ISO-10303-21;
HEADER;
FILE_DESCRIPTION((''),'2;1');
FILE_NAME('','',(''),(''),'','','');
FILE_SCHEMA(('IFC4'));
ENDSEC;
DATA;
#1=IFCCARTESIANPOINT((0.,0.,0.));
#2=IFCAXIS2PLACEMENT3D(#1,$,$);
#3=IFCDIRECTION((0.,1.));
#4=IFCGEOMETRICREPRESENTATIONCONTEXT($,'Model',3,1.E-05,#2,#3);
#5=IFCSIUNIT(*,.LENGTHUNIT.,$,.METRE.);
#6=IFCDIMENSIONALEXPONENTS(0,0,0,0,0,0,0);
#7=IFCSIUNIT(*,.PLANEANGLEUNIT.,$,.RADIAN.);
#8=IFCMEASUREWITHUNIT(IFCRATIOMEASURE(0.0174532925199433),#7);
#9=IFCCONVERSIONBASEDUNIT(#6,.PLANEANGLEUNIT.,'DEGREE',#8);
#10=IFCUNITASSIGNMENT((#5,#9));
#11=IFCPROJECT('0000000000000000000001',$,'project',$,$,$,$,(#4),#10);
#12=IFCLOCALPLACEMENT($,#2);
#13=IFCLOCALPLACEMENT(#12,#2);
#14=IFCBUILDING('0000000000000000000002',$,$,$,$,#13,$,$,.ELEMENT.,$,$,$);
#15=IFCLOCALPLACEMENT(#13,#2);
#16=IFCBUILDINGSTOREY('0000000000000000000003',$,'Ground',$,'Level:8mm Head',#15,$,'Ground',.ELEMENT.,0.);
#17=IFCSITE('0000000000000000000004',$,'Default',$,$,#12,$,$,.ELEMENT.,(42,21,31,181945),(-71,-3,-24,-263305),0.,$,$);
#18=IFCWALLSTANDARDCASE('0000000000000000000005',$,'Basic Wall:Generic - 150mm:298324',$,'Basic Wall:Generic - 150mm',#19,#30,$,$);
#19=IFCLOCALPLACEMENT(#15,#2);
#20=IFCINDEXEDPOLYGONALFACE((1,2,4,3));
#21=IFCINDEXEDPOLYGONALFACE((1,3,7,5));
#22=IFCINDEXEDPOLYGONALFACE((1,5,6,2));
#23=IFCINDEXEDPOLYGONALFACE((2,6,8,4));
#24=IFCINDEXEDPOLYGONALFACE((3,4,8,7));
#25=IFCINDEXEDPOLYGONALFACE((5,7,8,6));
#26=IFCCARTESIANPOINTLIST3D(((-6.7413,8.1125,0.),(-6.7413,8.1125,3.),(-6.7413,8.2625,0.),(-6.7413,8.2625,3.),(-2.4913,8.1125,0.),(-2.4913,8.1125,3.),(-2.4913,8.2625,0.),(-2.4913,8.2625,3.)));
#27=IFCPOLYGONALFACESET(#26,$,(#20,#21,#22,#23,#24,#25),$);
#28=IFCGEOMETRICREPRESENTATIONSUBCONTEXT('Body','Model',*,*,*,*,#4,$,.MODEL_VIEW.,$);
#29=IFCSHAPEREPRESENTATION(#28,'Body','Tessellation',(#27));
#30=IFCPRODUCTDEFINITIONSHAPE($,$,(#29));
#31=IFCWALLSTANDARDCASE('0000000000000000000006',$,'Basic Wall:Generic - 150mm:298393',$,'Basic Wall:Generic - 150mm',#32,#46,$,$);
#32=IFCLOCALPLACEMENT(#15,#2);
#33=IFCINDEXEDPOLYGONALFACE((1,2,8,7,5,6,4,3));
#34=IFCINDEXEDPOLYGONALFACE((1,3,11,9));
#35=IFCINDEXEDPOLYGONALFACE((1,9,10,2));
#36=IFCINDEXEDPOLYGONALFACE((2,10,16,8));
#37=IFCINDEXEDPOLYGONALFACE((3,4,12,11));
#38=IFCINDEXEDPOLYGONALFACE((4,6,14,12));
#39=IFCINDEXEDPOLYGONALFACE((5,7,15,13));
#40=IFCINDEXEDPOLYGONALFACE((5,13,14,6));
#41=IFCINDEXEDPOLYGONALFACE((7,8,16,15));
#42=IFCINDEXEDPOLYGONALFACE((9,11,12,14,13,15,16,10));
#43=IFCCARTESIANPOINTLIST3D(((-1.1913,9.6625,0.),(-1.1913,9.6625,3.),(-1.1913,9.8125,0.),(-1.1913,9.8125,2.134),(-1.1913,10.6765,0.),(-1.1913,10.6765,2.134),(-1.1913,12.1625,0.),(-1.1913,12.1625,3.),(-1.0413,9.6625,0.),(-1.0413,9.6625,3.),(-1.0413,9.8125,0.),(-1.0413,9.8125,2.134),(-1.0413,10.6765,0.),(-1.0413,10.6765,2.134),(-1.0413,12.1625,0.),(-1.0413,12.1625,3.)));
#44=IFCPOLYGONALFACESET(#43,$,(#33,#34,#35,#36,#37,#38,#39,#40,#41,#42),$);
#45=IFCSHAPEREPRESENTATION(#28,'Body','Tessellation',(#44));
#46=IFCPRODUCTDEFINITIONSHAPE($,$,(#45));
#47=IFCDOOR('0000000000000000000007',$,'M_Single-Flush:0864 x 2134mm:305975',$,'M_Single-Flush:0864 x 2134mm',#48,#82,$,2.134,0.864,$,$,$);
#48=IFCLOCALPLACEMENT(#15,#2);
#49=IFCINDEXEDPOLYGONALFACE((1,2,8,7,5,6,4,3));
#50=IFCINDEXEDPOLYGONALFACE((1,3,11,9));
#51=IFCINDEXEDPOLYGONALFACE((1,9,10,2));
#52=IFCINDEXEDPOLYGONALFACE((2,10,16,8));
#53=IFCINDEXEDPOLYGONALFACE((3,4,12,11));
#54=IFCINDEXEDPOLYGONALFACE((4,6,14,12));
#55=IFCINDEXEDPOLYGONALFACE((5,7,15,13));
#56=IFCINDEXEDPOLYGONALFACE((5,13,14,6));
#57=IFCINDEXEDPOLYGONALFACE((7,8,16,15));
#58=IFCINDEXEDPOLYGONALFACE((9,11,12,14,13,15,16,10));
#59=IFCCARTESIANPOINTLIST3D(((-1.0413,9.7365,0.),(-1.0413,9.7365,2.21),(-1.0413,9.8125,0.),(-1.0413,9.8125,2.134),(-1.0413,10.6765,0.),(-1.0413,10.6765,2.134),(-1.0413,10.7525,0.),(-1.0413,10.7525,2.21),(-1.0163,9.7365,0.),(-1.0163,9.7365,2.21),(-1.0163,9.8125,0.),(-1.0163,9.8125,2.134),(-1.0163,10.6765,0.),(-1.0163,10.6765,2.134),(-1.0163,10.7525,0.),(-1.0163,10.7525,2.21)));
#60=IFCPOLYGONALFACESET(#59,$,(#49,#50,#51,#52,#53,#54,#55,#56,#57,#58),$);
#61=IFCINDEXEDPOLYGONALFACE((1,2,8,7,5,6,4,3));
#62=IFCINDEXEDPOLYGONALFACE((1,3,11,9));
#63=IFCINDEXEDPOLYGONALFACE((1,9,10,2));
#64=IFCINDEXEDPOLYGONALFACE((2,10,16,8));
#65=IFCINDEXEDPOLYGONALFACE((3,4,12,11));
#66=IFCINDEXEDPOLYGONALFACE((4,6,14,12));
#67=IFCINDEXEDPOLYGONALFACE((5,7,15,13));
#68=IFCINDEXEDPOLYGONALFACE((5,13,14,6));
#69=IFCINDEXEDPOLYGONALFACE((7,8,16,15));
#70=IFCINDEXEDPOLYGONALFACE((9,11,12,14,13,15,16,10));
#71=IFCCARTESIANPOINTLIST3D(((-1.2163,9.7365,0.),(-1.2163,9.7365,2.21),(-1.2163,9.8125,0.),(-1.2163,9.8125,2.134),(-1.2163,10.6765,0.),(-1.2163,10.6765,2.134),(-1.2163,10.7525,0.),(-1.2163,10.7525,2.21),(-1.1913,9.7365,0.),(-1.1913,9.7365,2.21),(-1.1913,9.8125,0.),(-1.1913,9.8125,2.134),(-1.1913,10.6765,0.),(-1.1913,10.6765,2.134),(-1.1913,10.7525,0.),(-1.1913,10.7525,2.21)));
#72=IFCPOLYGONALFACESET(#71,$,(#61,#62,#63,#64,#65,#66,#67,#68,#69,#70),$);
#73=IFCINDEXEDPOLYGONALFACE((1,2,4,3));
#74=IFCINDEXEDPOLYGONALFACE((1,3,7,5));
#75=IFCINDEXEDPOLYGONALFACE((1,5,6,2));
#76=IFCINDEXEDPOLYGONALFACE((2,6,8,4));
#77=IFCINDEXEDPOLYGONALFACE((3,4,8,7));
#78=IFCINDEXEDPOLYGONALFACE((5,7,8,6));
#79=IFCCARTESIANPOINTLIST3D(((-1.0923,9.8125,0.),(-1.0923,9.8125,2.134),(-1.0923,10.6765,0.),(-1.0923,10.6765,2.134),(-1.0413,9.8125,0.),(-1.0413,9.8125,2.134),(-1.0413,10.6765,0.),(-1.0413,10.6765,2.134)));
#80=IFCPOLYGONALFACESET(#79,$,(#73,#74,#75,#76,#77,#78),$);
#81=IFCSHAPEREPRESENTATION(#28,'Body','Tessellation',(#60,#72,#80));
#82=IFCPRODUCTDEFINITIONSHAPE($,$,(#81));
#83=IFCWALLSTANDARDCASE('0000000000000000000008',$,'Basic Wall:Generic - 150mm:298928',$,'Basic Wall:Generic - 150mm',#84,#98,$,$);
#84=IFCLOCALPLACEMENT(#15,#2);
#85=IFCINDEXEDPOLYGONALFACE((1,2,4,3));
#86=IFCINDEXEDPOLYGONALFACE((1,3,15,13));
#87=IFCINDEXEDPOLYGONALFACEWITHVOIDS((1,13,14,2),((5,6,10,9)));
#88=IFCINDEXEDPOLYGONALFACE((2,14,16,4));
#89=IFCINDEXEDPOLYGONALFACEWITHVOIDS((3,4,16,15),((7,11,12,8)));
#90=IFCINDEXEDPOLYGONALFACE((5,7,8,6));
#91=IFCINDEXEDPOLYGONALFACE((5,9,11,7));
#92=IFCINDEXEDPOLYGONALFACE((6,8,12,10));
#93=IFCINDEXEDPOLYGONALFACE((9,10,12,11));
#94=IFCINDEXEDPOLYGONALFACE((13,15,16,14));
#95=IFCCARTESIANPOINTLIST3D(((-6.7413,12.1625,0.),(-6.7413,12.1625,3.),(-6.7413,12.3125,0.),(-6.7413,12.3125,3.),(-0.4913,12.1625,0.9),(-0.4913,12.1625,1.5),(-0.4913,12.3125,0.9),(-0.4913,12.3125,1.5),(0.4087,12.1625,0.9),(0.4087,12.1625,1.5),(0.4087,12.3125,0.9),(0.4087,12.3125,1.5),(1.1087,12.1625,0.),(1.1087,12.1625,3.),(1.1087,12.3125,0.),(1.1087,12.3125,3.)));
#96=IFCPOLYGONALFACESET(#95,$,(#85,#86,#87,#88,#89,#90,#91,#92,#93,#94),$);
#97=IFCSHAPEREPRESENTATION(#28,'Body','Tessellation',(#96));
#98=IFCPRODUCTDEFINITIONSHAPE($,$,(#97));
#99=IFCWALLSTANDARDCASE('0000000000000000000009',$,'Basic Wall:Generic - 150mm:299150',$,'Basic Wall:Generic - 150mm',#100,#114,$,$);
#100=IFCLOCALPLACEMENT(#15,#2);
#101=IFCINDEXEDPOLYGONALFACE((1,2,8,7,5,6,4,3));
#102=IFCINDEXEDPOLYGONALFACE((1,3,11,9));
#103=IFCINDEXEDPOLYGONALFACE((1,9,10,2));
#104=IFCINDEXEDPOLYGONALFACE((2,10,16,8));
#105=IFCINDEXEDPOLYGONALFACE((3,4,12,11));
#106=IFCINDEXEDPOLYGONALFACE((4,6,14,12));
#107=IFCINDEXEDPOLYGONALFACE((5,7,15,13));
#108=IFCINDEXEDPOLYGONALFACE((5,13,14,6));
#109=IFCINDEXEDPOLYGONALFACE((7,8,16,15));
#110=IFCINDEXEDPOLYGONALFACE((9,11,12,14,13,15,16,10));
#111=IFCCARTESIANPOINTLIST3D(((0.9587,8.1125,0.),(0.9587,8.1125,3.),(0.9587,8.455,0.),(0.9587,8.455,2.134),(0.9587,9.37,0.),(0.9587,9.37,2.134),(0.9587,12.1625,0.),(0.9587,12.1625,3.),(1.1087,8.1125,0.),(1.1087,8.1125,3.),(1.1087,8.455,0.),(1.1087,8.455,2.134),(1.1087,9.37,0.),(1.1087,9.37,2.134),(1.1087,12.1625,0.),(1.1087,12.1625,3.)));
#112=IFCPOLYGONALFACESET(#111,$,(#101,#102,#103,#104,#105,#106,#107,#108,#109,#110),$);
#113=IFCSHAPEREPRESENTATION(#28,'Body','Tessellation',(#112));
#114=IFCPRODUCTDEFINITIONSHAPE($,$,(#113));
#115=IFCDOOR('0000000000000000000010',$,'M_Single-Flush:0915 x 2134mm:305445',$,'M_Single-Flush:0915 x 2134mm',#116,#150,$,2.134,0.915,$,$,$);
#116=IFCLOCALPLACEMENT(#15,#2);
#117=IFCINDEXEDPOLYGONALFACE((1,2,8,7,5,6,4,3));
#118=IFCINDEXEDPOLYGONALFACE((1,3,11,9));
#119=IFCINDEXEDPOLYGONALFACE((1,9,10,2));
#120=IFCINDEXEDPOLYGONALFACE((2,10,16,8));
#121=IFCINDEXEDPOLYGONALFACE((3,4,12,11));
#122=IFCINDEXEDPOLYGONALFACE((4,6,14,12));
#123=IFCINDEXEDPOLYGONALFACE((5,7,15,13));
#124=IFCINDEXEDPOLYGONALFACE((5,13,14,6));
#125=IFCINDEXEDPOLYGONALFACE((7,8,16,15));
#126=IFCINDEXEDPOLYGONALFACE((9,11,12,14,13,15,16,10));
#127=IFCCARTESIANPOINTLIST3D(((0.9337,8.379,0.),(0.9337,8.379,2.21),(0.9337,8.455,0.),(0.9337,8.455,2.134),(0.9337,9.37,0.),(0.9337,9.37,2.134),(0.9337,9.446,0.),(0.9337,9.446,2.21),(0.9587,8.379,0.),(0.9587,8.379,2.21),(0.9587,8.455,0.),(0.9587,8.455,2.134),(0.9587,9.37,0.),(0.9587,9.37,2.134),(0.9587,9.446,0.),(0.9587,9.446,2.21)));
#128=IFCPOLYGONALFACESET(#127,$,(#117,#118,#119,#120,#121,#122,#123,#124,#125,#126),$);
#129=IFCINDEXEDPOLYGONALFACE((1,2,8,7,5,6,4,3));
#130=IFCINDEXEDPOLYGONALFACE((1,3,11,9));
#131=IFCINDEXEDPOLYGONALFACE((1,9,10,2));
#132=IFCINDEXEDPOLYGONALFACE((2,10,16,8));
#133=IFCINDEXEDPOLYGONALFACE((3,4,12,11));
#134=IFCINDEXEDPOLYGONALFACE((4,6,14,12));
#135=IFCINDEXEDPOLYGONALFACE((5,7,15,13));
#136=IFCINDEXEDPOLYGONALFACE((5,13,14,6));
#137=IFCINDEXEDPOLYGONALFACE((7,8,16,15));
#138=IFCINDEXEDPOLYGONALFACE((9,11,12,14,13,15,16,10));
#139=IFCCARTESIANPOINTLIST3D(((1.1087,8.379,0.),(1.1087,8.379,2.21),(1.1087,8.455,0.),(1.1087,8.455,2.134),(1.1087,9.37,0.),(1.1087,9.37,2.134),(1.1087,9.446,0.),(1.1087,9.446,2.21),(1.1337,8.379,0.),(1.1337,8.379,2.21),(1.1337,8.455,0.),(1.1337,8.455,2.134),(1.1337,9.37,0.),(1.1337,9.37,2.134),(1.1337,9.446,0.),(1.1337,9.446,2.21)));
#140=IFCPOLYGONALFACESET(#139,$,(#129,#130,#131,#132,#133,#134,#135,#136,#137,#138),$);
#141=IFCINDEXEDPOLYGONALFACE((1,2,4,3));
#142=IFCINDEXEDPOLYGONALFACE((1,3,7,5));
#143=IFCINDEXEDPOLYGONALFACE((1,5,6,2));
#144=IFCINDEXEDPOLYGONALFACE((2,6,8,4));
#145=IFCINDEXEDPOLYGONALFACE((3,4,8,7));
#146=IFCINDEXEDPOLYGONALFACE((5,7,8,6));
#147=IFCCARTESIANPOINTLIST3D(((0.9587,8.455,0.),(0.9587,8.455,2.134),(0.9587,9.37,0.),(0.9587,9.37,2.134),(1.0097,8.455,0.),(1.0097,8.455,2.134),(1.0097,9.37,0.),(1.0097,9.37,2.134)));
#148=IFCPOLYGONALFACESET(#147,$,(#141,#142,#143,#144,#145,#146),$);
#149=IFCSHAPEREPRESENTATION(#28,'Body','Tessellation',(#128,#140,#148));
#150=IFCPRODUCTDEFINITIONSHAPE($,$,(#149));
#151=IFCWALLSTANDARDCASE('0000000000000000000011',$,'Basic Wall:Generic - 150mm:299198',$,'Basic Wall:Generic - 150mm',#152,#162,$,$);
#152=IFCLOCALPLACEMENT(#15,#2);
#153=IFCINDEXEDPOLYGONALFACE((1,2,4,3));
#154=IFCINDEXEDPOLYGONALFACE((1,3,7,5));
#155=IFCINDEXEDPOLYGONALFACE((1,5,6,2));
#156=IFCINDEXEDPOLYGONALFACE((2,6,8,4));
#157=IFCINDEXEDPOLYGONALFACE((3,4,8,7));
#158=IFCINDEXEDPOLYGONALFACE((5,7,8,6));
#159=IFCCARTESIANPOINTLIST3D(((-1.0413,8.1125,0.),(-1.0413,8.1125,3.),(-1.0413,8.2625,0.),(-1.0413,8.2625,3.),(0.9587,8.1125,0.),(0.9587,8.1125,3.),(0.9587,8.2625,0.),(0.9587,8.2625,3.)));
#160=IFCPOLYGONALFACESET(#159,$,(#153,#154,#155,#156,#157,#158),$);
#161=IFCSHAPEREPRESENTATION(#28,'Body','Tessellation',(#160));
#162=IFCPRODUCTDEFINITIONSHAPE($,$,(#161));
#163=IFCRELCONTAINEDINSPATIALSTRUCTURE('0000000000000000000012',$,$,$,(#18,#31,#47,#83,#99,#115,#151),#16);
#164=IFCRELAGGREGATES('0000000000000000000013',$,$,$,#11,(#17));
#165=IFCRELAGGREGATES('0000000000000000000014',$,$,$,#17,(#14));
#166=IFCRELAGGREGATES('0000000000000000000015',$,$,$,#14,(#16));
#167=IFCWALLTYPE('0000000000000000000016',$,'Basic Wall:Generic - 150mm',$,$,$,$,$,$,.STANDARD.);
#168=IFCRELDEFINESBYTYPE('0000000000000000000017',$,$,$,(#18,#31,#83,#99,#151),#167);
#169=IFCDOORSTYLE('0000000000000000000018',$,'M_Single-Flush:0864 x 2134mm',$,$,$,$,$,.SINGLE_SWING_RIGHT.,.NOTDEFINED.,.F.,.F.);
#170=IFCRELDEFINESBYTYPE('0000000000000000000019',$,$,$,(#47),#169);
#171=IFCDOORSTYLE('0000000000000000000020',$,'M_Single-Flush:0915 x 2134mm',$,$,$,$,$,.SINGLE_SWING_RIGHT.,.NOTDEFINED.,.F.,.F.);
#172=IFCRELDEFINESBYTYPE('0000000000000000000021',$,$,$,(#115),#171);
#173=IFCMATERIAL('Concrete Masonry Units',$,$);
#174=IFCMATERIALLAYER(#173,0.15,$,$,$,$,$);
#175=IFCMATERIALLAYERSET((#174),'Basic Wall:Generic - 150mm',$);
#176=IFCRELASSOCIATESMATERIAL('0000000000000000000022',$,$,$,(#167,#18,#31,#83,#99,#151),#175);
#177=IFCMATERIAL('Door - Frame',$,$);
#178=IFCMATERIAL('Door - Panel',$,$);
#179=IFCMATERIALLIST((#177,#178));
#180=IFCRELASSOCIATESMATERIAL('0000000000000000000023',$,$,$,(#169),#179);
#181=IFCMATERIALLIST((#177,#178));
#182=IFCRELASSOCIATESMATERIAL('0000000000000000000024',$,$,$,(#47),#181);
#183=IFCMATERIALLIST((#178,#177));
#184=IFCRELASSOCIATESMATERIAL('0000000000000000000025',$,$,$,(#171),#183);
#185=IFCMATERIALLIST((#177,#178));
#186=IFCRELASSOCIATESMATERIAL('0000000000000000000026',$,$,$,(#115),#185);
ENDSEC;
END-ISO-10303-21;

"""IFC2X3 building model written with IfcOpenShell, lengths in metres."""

from ifc_helpers import new_model, entity, si_unit, converted_unit, direction, frame, frame_2d, origin, place, context, subcontext, project, spatial, polyline, rectangle, outline, extrude, source, transform, mapped, material, material_list, layer, layer_set, layer_usage, type_object, type_shapes, element, fill, save


model = new_model("IFC2X3")

# Units and contexts
model_context = context("Model", 3, precision=1e-05, world=origin(), true_north=direction((0.0, 1.0)))
body_context = subcontext(model_context, "Body", "Model", "MODEL_VIEW")
ifc_project = project(units=[si_unit("LENGTHUNIT", "METRE"), converted_unit("PLANEANGLEUNIT", "DEGREE", entity("IfcRatioMeasure", 0.0174532925199433), si_unit("PLANEANGLEUNIT", "RADIAN"), dimensions=[0, 0, 0, 0, 0, 0, 0])], contexts=[model_context])

# Site, building, storey
site_placement = place(None, origin())
site = spatial("IfcSite", under=ifc_project, at=site_placement, Name="Default", CompositionType="ELEMENT", RefLatitude=(42, 21, 31, 181945), RefLongitude=(-71, -3, -24, -263305), RefElevation=0.0)
building_placement = place(site_placement, origin())
building = spatial("IfcBuilding", under=site, at=building_placement, CompositionType="ELEMENT")
storey_placement = place(building_placement, origin())
storey = spatial("IfcBuildingStorey", under=building, at=storey_placement, Name="Ground", ObjectType="Level:8mm Head", LongName="Ground", CompositionType="ELEMENT", Elevation=0.0)

# Wall
ifc_material_1 = material(Name="Concrete Masonry Units")
ifc_layer = layer(ifc_material_1, 0.15)
ifc_layer_set = layer_set([ifc_layer], Name="Basic Wall:Generic - 150mm")
ifc_layer_usage_1 = layer_usage(ifc_layer_set, "AXIS2", "POSITIVE", -0.075)
wall_type = type_object("IfcWallType", Name="Basic Wall:Generic - 150mm", PredefinedType="STANDARD", material=ifc_layer_set)
wall_1_placement = place(storey_placement, frame((-6.7413, 8.1875, 0.0)))
element("IfcWallStandardCase", 1, at=wall_1_placement, inside=storey, type_object=wall_type, material=ifc_layer_usage_1, Name="Basic Wall:Generic - 150mm:298324", ObjectType="Basic Wall:Generic - 150mm", context=body_context, shape_type="SweptSolid", body=[
    extrude(rectangle(XDim=4.25, YDim=0.15, at=frame_2d((2.125, 0.0), x_axis=(-1.0, 0.0))), origin(), (0.0, 0.0, 1.0), 3.0),
])

# Wall, opening, door
ifc_layer_usage_2 = layer_usage(ifc_layer_set, "AXIS2", "NEGATIVE", 0.075)
wall_2_placement = place(storey_placement, frame((-1.1163, 12.1625, 0.0), z_axis=(0.0, 0.0, 1.0), x_axis=(0.0, -1.0, 0.0)))
wall_2 = element("IfcWallStandardCase", 2, at=wall_2_placement, inside=storey, type_object=wall_type, material=ifc_layer_usage_2, Name="Basic Wall:Generic - 150mm:298393", ObjectType="Basic Wall:Generic - 150mm", context=body_context, shape_type="SweptSolid", body=[
    extrude(rectangle(XDim=2.5, YDim=0.15, at=frame_2d((1.25, 0.0), x_axis=(-1.0, 0.0))), origin(), (0.0, 0.0, 1.0), 3.0),
])
opening_1_placement = place(wall_2_placement, frame((1.486, -0.075, 0.0)))
opening_1 = element("IfcOpeningElement", 3, at=opening_1_placement, cuts=wall_2, ObjectType="Opening", context=body_context, shape_type="SweptSolid", body=[
    extrude(rectangle(XDim=0.864, YDim=2.134, at=frame_2d((1.067, 0.432), x_axis=(0.0, 1.0))), frame((0.0, 0.0, 0.0), z_axis=(0.0, 1.0, 0.0), x_axis=(0.0, 0.0, 1.0)), (0.0, 0.0, 1.0), 0.15),
])
ifc_material_2 = material(Name="Door - Frame")
ifc_material_3 = material(Name="Door - Panel")
ifc_material_list_1 = material_list([ifc_material_2, ifc_material_3])
ifc_material_list_2 = material_list([ifc_material_2, ifc_material_3])
door_style_1 = type_object("IfcDoorStyle", Name="M_Single-Flush:0864 x 2134mm", ConstructionType="NOTDEFINED", OperationType="SINGLE_SWING_RIGHT", ParameterTakesPrecedence=False, Sizeable=False, material=ifc_material_list_2)
shared_shape_1 = source(origin(), body_context, "Body", "SweptSolid", [
    extrude(outline(polyline([(-0.508, -1.124), (0.508, -1.124), (0.508, 1.086), (0.432, 1.086), (0.432, -1.048), (-0.432, -1.048), (-0.432, 1.086), (-0.508, 1.086), (-0.508, -1.124)])), frame((0.432, 0.15, 1.086), z_axis=(0.0, 1.0, 0.0), x_axis=(1.0, 0.0, 0.0)), (0.0, 0.0, 1.0), 0.025),
    extrude(outline(polyline([(-1.124, -0.508), (1.086, -0.508), (1.086, -0.432), (-1.048, -0.432), (-1.048, 0.432), (1.086, 0.432), (1.086, 0.508), (-1.124, 0.508), (-1.124, -0.508)])), frame((0.432, -0.025, 1.086), z_axis=(0.0, 1.0, 0.0), x_axis=(0.0, 0.0, -1.0)), (0.0, 0.0, 1.0), 0.025),
    extrude(rectangle(XDim=0.051, YDim=0.864, at=frame_2d((0.0, 0.0), x_axis=(1.0, 0.0))), frame((0.432, 0.1245, 0.0), z_axis=(0.0, 0.0, 1.0), x_axis=(0.0, 1.0, 0.0)), (0.0, 0.0, 1.0), 2.134),
])
type_shapes(door_style_1, [shared_shape_1])
door_1_placement = place(opening_1_placement, origin())
door_1 = element("IfcDoor", 4, at=door_1_placement, inside=storey, type_object=door_style_1, material=ifc_material_list_1, Name="M_Single-Flush:0864 x 2134mm:305975", ObjectType="M_Single-Flush:0864 x 2134mm", OverallHeight=2.134, OverallWidth=0.864, context=body_context, shape_type="MappedRepresentation", body=[
    mapped(shared_shape_1, transform((0.0, 0.0, 0.0), scale=1.0)),
])
fill(opening_1, door_1)

# Wall, opening
ifc_layer_usage_3 = layer_usage(ifc_layer_set, "AXIS2", "NEGATIVE", 0.075)
wall_3_placement = place(storey_placement, frame((-6.7413, 12.2375, 0.0)))
wall_3 = element("IfcWallStandardCase", 5, at=wall_3_placement, inside=storey, type_object=wall_type, material=ifc_layer_usage_3, Name="Basic Wall:Generic - 150mm:298928", ObjectType="Basic Wall:Generic - 150mm", context=body_context, shape_type="SweptSolid", body=[
    extrude(rectangle(XDim=7.85, YDim=0.15, at=frame_2d((3.925, 0.0), x_axis=(-1.0, 0.0))), origin(), (0.0, 0.0, 1.0), 3.0),
])
opening_2_placement = place(wall_3_placement, frame((7.15, 0.075, 0.9)))
element("IfcOpeningElement", 6, at=opening_2_placement, cuts=wall_3, ObjectType="Opening", context=body_context, shape_type="SweptSolid", body=[
    extrude(rectangle(XDim=0.6, YDim=0.9, at=frame_2d((0.3, 0.45), x_axis=(-1.0, 0.0))), frame((0.0, 0.0, 0.0), z_axis=(0.0, -1.0, 0.0), x_axis=(0.0, 0.0, 1.0)), (0.0, 0.0, 1.0), 0.15),
])

# Wall, opening, door
ifc_layer_usage_4 = layer_usage(ifc_layer_set, "AXIS2", "POSITIVE", -0.075)
wall_4_placement = place(storey_placement, frame((1.0337, 12.1625, 0.0), z_axis=(0.0, 0.0, 1.0), x_axis=(0.0, -1.0, 0.0)))
wall_4 = element("IfcWallStandardCase", 7, at=wall_4_placement, inside=storey, type_object=wall_type, material=ifc_layer_usage_4, Name="Basic Wall:Generic - 150mm:299150", ObjectType="Basic Wall:Generic - 150mm", context=body_context, shape_type="SweptSolid", body=[
    extrude(rectangle(XDim=4.05, YDim=0.15, at=frame_2d((2.025, 0.0), x_axis=(-1.0, 0.0))), origin(), (0.0, 0.0, 1.0), 3.0),
])
opening_3_placement = place(wall_4_placement, frame((3.7075, 0.075, 0.0)))
opening_3 = element("IfcOpeningElement", 8, at=opening_3_placement, cuts=wall_4, ObjectType="Opening", context=body_context, shape_type="SweptSolid", body=[
    extrude(rectangle(XDim=0.915, YDim=2.134, at=frame_2d((1.067, 0.4575), x_axis=(0.0, 1.0))), frame((0.0, 0.0, 0.0), z_axis=(0.0, -1.0, 0.0), x_axis=(0.0, 0.0, 1.0)), (0.0, 0.0, 1.0), 0.15),
])
ifc_material_list_3 = material_list([ifc_material_2, ifc_material_3])
ifc_material_list_4 = material_list([ifc_material_3, ifc_material_2])
door_style_2 = type_object("IfcDoorStyle", Name="M_Single-Flush:0915 x 2134mm", ConstructionType="NOTDEFINED", OperationType="SINGLE_SWING_RIGHT", ParameterTakesPrecedence=False, Sizeable=False, material=ifc_material_list_4)
shared_shape_2 = source(origin(), body_context, "Body", "SweptSolid", [
    extrude(outline(polyline([(-0.5335, -1.124), (0.5335, -1.124), (0.5335, 1.086), (0.4575, 1.086), (0.4575, -1.048), (-0.4575, -1.048), (-0.4575, 1.086), (-0.5335, 1.086), (-0.5335, -1.124)])), frame((0.4575, 0.15, 1.086), z_axis=(0.0, 1.0, 0.0), x_axis=(1.0, 0.0, 0.0)), (0.0, 0.0, 1.0), 0.025),
    extrude(outline(polyline([(-1.124, -0.5335), (1.086, -0.5335), (1.086, -0.4575), (-1.048, -0.4575), (-1.048, 0.4575), (1.086, 0.4575), (1.086, 0.5335), (-1.124, 0.5335), (-1.124, -0.5335)])), frame((0.4575, -0.025, 1.086), z_axis=(0.0, 1.0, 0.0), x_axis=(0.0, 0.0, -1.0)), (0.0, 0.0, 1.0), 0.025),
    extrude(rectangle(XDim=0.051, YDim=0.915, at=frame_2d((0.0, 0.0), x_axis=(1.0, 0.0))), frame((0.4575, 0.1245, 0.0), z_axis=(0.0, 0.0, 1.0), x_axis=(0.0, 1.0, 0.0)), (0.0, 0.0, 1.0), 2.134),
])
type_shapes(door_style_2, [shared_shape_2])
door_2_placement = place(opening_3_placement, frame((0.0, 0.0, 0.0), z_axis=(0.0, 0.0, 1.0), x_axis=(-1.0, 0.0, 0.0)))
door_2 = element("IfcDoor", 9, at=door_2_placement, inside=storey, type_object=door_style_2, material=ifc_material_list_3, Name="M_Single-Flush:0915 x 2134mm:305445", ObjectType="M_Single-Flush:0915 x 2134mm", OverallHeight=2.134, OverallWidth=0.915, context=body_context, shape_type="MappedRepresentation", body=[
    mapped(shared_shape_2, transform((0.0, 0.0, 0.0), scale=1.0)),
])
fill(opening_3, door_2)

# Wall
ifc_layer_usage_5 = layer_usage(ifc_layer_set, "AXIS2", "NEGATIVE", 0.075)
wall_5_placement = place(storey_placement, frame((0.9587, 8.1875, 0.0), z_axis=(0.0, 0.0, 1.0), x_axis=(-1.0, 0.0, 0.0)))
element("IfcWallStandardCase", 10, at=wall_5_placement, inside=storey, type_object=wall_type, material=ifc_layer_usage_5, Name="Basic Wall:Generic - 150mm:299198", ObjectType="Basic Wall:Generic - 150mm", context=body_context, shape_type="SweptSolid", body=[
    extrude(rectangle(XDim=2.0, YDim=0.15, at=frame_2d((1.0, 0.0), x_axis=(-1.0, 0.0))), origin(), (0.0, 0.0, 1.0), 3.0),
])

save(model, "model.ifc")
